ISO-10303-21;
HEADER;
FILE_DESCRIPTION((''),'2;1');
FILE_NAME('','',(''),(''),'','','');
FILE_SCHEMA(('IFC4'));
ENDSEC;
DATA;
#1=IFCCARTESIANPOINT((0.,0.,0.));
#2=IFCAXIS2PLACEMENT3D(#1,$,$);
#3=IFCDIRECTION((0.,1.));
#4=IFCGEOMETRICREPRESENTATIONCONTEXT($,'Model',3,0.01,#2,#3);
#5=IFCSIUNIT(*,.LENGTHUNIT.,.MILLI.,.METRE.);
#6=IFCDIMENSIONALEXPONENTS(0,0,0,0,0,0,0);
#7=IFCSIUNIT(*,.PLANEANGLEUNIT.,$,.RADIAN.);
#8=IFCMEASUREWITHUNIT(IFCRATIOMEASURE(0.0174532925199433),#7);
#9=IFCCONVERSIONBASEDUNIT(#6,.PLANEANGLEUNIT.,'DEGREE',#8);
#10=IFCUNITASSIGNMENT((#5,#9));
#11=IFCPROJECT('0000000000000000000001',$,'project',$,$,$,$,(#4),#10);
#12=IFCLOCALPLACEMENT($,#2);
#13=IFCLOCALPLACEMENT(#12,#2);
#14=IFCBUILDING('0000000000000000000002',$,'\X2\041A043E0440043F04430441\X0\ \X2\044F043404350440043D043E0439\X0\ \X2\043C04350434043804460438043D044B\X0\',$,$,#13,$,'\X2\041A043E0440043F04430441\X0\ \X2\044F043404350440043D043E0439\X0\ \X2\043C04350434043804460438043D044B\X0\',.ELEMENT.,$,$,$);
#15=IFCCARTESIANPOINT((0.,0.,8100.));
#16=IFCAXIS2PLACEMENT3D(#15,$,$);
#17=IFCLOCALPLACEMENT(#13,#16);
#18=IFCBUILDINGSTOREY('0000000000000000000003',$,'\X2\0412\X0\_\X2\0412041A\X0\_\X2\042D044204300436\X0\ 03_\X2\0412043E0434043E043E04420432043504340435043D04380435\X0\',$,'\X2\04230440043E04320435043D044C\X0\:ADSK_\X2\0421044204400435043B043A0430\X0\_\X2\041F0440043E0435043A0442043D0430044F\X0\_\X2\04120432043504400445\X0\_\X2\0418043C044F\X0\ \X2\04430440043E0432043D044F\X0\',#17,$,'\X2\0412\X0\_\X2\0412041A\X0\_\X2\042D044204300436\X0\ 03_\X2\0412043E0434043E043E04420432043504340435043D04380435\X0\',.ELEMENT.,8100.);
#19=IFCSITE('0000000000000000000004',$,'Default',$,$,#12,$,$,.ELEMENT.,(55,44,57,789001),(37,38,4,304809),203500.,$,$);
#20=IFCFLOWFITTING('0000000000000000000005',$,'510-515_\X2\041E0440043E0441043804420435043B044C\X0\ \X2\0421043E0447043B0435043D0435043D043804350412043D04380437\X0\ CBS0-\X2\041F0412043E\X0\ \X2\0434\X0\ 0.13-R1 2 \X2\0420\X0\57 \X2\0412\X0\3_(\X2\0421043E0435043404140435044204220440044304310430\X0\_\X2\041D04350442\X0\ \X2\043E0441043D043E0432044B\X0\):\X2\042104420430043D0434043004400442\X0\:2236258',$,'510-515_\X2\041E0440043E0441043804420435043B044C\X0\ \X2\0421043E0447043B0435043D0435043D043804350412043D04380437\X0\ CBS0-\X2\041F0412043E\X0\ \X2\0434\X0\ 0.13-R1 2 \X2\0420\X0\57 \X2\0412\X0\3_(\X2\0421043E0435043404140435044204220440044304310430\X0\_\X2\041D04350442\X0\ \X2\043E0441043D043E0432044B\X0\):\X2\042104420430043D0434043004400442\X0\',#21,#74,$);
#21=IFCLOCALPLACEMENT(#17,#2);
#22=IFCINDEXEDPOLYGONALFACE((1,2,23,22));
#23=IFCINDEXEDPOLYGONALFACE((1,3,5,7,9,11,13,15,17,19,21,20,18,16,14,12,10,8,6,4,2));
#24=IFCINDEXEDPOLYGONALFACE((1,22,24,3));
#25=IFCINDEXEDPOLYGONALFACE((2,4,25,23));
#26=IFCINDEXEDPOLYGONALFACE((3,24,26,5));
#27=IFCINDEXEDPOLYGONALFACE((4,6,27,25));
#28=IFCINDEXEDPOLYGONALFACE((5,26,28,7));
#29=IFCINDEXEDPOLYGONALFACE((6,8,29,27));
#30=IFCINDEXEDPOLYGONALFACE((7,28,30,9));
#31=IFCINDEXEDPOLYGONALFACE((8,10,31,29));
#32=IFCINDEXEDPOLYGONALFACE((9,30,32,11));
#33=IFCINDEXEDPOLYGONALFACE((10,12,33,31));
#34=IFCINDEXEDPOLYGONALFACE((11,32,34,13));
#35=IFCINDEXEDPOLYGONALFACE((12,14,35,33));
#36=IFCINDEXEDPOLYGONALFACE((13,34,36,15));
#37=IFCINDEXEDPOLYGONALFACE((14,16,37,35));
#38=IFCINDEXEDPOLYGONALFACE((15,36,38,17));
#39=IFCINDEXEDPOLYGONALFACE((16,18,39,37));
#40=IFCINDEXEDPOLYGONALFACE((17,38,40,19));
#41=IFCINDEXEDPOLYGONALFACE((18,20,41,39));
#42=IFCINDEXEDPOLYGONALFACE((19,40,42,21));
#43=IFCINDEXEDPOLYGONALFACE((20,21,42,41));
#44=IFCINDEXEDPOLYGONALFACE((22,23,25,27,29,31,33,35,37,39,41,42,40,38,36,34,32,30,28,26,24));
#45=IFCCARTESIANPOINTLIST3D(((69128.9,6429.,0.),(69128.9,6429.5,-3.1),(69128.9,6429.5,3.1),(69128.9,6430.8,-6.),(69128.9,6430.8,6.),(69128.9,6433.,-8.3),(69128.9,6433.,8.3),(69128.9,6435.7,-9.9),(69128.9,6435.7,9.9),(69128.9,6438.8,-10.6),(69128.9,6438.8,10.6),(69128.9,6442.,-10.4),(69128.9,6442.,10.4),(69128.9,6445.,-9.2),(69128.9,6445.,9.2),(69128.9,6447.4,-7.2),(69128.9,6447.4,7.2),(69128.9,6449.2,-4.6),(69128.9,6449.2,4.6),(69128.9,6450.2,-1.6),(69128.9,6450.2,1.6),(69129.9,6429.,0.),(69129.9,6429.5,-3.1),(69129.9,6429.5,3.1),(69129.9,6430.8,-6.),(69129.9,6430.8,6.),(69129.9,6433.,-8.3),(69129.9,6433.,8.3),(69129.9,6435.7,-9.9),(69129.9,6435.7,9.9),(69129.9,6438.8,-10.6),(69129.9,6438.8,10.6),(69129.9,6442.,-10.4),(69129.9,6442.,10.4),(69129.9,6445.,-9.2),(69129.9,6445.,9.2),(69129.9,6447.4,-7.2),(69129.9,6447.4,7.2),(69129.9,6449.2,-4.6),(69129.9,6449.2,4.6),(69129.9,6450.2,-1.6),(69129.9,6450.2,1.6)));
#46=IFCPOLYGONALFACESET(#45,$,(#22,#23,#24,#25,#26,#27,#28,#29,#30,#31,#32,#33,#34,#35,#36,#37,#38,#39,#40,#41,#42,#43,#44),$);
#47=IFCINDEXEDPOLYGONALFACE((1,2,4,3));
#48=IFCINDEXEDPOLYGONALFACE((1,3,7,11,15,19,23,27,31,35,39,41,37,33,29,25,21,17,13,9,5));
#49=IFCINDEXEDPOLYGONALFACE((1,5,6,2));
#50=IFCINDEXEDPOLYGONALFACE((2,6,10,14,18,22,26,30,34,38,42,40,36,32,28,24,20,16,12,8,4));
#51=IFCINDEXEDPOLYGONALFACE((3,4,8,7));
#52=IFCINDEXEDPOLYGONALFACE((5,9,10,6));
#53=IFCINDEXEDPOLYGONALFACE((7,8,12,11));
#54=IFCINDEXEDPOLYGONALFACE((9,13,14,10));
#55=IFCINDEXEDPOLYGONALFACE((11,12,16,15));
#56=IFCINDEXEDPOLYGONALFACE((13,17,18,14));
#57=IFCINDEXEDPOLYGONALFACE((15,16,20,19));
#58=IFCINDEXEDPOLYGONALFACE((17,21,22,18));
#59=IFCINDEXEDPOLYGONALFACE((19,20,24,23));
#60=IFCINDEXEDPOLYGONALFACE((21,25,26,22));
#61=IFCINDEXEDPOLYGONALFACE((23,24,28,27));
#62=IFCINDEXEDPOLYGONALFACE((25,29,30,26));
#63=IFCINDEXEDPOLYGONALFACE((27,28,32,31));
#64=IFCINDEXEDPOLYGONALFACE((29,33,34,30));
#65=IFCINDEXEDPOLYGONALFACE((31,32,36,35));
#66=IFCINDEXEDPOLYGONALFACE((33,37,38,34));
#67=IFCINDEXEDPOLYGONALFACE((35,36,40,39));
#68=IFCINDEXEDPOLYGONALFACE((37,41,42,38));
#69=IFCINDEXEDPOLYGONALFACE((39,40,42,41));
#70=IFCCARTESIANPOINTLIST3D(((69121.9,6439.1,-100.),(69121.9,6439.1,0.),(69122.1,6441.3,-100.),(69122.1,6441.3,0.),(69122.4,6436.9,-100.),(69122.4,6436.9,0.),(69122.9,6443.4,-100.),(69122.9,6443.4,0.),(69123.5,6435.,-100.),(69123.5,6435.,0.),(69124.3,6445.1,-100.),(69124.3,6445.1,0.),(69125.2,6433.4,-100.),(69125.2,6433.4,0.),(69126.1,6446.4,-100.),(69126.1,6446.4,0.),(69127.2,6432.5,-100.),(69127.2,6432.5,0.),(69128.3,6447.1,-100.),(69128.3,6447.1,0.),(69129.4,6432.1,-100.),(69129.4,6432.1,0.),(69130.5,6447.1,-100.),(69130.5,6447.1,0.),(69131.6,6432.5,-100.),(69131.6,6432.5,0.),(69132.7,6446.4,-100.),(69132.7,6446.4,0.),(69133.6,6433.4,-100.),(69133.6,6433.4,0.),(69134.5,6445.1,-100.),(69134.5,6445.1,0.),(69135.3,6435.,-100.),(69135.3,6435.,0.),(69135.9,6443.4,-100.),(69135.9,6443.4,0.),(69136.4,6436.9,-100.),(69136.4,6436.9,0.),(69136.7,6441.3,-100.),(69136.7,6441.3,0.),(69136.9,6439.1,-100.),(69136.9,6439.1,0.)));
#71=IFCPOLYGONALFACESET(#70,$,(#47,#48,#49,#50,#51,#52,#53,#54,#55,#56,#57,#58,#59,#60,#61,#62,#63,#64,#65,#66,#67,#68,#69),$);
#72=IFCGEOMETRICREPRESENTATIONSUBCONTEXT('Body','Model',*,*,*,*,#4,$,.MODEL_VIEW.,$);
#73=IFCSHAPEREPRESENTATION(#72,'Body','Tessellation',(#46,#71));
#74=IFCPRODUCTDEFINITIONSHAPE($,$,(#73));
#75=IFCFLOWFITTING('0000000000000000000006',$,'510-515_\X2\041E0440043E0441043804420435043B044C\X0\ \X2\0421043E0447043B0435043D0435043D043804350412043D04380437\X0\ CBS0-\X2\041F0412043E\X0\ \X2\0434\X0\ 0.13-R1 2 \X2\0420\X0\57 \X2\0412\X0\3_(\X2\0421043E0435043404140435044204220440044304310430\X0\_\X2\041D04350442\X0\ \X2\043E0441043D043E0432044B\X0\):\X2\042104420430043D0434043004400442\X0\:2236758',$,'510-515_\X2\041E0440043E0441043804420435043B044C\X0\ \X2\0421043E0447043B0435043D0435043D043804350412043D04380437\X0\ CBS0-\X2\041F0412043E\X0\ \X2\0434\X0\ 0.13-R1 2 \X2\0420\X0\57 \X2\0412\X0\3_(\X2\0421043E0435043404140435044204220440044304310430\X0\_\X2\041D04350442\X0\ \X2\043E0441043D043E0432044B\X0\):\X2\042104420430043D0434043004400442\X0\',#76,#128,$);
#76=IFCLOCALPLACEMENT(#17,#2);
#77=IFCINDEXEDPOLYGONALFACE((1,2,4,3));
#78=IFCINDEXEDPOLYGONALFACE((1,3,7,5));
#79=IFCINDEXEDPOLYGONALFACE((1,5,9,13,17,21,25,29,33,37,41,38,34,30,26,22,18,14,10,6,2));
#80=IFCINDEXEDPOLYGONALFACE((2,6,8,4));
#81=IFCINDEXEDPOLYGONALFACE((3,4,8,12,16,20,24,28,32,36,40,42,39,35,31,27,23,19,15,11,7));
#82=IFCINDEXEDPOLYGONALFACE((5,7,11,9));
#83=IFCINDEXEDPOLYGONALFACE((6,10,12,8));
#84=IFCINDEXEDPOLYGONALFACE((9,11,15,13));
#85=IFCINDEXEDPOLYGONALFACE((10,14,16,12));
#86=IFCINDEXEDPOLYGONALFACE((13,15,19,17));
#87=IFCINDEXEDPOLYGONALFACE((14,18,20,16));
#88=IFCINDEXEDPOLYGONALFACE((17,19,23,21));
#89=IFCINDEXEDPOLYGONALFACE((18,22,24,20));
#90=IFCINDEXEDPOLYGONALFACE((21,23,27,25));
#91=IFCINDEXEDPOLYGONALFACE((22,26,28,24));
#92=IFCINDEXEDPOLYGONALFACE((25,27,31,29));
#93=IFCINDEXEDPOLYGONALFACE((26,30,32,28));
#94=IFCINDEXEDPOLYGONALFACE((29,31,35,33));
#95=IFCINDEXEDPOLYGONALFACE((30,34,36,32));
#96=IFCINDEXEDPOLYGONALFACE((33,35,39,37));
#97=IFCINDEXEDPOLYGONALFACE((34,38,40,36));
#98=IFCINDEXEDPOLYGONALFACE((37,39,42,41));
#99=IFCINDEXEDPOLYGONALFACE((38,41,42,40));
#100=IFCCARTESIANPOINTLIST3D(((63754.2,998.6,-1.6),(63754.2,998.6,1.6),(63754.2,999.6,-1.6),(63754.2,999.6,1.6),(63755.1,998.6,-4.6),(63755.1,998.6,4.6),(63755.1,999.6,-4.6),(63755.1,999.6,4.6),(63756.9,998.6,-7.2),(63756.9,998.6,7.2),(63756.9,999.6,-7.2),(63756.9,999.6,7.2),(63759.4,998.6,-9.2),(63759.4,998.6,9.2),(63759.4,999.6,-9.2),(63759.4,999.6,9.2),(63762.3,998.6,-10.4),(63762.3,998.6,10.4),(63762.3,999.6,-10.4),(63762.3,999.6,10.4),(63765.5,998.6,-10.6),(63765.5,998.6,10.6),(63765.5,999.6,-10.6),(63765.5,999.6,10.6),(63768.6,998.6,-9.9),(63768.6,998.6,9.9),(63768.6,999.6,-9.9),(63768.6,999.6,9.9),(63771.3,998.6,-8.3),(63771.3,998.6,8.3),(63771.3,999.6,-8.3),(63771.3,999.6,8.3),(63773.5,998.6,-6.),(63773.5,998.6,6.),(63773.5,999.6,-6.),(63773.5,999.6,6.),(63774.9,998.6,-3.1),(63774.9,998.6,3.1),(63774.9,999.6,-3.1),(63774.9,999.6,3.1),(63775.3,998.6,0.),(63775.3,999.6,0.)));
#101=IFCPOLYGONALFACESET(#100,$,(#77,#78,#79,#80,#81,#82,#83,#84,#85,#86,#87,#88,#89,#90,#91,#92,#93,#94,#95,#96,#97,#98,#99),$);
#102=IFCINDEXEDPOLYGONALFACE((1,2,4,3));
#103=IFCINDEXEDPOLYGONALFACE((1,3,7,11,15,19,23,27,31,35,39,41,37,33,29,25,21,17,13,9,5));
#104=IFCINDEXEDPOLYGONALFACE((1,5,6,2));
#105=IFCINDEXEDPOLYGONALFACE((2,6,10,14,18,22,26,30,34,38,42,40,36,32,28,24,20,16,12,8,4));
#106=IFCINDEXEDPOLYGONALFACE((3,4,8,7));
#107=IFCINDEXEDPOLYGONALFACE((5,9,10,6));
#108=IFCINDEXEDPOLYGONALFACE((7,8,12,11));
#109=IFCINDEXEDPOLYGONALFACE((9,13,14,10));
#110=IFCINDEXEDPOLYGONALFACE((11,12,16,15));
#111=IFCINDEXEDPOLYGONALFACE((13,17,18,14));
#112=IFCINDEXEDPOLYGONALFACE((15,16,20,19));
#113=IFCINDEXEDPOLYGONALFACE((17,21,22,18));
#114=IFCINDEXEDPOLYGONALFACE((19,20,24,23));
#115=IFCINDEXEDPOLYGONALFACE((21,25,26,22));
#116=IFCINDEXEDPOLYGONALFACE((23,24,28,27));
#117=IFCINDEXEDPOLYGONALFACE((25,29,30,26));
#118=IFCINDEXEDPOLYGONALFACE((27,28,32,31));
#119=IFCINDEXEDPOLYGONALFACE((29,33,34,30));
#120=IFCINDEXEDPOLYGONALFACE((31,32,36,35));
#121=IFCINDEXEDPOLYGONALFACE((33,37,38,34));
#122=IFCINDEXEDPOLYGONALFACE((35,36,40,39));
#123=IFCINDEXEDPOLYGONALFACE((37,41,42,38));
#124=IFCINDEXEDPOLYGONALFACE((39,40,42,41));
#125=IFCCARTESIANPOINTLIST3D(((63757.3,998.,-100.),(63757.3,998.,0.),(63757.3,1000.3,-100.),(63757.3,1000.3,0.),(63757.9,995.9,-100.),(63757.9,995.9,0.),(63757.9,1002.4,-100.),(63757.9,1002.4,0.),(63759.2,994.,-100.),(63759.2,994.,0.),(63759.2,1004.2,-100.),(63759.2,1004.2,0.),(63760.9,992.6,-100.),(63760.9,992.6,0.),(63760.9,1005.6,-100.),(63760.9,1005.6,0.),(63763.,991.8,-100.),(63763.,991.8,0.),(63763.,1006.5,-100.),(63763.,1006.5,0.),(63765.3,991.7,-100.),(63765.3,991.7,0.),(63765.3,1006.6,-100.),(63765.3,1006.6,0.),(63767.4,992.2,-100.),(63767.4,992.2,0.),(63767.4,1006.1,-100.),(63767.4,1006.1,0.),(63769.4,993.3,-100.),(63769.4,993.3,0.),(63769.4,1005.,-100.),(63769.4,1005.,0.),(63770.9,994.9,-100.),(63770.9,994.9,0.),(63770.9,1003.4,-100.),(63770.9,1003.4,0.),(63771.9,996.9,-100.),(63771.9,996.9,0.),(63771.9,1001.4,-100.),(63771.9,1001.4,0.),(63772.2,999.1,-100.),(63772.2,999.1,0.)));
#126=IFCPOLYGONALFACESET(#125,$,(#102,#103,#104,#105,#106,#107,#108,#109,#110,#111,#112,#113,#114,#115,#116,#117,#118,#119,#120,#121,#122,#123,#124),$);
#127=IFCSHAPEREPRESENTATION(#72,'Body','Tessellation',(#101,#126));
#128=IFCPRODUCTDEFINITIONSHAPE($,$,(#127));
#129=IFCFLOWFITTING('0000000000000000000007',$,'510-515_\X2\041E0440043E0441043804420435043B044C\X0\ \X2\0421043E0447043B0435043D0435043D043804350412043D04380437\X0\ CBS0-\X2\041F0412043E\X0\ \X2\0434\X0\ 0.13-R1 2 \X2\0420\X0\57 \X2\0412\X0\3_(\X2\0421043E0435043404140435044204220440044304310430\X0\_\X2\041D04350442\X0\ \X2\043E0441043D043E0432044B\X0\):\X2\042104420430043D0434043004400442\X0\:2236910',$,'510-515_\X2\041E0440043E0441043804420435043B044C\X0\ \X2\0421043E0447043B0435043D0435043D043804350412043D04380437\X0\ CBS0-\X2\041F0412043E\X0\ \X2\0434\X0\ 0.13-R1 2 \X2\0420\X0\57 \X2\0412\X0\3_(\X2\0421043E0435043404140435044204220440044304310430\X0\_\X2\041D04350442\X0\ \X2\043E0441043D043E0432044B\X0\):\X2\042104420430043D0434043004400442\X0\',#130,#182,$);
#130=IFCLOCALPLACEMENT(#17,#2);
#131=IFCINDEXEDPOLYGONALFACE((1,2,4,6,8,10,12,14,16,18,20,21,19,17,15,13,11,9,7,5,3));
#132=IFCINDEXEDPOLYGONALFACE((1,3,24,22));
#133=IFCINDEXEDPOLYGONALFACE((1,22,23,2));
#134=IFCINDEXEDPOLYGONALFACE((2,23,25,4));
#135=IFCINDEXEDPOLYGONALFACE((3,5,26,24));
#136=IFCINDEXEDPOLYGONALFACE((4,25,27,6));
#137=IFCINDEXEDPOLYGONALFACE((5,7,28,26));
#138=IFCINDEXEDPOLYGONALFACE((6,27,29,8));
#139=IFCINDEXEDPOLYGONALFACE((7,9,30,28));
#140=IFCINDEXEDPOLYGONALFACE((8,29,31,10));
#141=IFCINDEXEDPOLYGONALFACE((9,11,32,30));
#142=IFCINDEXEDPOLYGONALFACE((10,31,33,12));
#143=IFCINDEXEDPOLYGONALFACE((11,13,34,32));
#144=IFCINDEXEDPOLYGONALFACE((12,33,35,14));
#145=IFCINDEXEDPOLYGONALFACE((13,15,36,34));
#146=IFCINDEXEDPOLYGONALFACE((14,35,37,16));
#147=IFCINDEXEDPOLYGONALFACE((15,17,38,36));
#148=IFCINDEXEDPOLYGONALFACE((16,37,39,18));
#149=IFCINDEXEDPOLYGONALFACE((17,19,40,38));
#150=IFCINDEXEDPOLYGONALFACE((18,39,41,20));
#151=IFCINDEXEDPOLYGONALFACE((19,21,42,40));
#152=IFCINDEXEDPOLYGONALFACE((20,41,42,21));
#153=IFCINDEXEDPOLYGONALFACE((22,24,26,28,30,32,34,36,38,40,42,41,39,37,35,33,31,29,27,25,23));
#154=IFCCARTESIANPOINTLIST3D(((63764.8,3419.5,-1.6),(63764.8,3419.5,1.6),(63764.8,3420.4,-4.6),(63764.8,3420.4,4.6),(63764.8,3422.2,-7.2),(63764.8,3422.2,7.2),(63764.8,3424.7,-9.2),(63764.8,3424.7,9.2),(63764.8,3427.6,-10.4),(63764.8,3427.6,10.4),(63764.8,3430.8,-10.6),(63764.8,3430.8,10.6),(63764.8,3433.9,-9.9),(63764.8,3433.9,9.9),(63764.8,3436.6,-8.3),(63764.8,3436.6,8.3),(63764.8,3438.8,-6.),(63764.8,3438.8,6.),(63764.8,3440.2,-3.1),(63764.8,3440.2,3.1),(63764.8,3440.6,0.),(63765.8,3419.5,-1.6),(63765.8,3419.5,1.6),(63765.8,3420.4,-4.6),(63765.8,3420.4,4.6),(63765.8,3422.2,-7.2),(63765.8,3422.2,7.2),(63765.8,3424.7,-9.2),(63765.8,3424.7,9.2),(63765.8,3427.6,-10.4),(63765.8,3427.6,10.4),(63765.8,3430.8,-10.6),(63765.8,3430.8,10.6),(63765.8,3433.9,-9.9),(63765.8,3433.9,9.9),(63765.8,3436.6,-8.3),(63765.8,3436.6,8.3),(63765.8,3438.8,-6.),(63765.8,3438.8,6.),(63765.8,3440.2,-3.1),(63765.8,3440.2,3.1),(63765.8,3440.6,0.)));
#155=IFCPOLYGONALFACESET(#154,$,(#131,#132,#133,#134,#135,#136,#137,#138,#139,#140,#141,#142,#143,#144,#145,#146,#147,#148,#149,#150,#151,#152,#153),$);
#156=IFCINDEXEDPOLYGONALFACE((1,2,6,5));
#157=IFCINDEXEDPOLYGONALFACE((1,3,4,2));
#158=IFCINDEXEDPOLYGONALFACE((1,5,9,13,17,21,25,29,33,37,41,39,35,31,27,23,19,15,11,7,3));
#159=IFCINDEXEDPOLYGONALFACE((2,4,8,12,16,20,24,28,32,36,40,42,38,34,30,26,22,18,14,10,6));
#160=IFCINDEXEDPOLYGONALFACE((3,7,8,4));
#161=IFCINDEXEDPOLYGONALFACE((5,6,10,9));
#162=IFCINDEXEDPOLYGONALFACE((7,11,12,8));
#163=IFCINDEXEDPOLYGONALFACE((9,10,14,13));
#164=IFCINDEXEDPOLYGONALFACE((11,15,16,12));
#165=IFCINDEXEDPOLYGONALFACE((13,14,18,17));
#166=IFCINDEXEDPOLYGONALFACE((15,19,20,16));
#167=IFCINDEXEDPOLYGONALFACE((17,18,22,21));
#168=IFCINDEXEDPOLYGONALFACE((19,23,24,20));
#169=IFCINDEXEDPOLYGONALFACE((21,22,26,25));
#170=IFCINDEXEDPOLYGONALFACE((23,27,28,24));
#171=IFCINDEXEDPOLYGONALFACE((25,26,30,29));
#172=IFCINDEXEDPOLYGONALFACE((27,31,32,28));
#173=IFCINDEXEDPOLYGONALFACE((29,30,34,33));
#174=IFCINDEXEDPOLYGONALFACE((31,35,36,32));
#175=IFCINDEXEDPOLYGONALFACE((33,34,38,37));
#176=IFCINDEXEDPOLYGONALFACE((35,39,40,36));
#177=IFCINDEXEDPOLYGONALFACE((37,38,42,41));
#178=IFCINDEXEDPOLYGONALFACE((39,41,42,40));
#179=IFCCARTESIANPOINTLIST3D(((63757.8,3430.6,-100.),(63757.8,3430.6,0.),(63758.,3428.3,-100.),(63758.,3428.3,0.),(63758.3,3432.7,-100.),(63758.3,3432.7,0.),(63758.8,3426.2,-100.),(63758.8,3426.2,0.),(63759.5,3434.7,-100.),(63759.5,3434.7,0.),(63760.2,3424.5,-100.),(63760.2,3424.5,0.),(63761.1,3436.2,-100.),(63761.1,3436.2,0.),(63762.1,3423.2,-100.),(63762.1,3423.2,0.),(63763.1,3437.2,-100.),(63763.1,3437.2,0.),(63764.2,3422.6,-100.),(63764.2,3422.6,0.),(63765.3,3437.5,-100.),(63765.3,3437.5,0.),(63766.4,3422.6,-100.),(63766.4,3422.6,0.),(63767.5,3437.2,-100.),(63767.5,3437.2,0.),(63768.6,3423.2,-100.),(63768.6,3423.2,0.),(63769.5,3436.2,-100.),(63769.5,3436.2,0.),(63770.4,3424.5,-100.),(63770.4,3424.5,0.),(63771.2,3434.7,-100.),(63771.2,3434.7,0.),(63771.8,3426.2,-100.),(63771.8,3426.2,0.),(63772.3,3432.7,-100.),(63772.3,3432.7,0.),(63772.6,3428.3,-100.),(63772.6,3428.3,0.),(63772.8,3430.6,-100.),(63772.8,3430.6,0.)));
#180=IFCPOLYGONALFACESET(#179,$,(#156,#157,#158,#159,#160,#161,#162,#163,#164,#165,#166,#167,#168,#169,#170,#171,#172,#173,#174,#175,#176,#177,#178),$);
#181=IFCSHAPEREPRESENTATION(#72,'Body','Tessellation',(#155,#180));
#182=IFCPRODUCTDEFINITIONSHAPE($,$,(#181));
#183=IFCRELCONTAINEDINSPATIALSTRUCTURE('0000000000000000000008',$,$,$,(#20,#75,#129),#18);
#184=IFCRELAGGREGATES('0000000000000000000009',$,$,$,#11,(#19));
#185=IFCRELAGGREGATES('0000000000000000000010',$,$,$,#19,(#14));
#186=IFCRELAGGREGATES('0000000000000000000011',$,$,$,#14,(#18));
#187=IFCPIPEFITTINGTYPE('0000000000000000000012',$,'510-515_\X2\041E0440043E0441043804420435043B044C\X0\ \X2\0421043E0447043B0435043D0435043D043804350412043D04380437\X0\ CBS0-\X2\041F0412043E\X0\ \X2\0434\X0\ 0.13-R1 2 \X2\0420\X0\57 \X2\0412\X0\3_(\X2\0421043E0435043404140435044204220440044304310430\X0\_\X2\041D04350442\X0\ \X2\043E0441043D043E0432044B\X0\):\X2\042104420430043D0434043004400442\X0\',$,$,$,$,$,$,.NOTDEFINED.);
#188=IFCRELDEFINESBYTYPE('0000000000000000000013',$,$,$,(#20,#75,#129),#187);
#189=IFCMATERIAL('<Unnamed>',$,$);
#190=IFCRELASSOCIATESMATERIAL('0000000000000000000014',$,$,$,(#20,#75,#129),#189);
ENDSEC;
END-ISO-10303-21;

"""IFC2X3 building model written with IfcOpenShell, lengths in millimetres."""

from ifc_helpers import new_model, entity, si_unit, converted_unit, direction, frame, origin, origin_2d_with_axis, place, context, subcontext, project, spatial, circle, extrude, source, transform, mapped, material, type_object, type_shapes, element, save


model = new_model("IFC2X3")

# Units and contexts
model_context = context("Model", 3, precision=0.01, world=origin(), true_north=direction((0.0, 1.0)))
body_context = subcontext(model_context, "Body", "Model", "MODEL_VIEW")
ifc_project = project(units=[si_unit("LENGTHUNIT", "METRE", prefix="MILLI"), converted_unit("PLANEANGLEUNIT", "DEGREE", entity("IfcRatioMeasure", 0.0174532925199433), si_unit("PLANEANGLEUNIT", "RADIAN"), dimensions=[0, 0, 0, 0, 0, 0, 0])], contexts=[model_context])

# Site, building, storey
site_placement = place(None, origin())
site = spatial("IfcSite", under=ifc_project, at=site_placement, Name="Default", CompositionType="ELEMENT", RefLatitude=(55, 44, 57, 789001), RefLongitude=(37, 38, 4, 304809), RefElevation=203500.0)
building_placement = place(site_placement, origin())
building = spatial("IfcBuilding", under=site, at=building_placement, Name="Корпус ядерной медицины", LongName="Корпус ядерной медицины", CompositionType="ELEMENT")
storey_placement = place(building_placement, frame((0.0, 0.0, 8100.0)))
storey = spatial("IfcBuildingStorey", under=building, at=storey_placement, Name="В_ВК_Этаж 03_Водоотведение", ObjectType="Уровень:ADSK_Стрелка_Проектная_Вверх_Имя уровня", LongName="В_ВК_Этаж 03_Водоотведение", CompositionType="ELEMENT", Elevation=8100.0)

# Flow fittings
ifc_material_1 = material(Name="<Unnamed>")
pipe_fitting_type = type_object("IfcPipeFittingType", Name="510-515_Ороситель СочленениеВниз CBS0-ПВо д 0.13-R1 2 Р57 В3_(СоедДетТруба_Нет основы):Стандарт", PredefinedType="NOTDEFINED")
shared_shape_1 = source(origin(), body_context, "Body", "SweptSolid", [
    extrude(circle(Radius=10.7, at=origin_2d_with_axis()), frame((-0.5, 0.0, 0.0), z_axis=(1.0, 0.0, 0.0), x_axis=(0.0, 1.0, 0.0)), (0.0, 0.0, 1.0), 1.0),
    extrude(circle(Radius=7.5, at=origin_2d_with_axis()), frame((0.0, 0.0, -100.0), z_axis=(0.0, 0.0, 1.0), x_axis=(0.0, 1.0, 0.0)), (0.0, 0.0, 1.0), 100.0),
])
type_shapes(pipe_fitting_type, [shared_shape_1])
for number, where, z_axis, x_axis, name in (
    (1, (69129.4, 6439.6, 0.0), (0.0, 0.0, 1.0), (-1.0, 0.0, 0.0), "510-515_Ороситель СочленениеВниз CBS0-ПВо д 0.13-R1 2 Р57 В3_(СоедДетТруба_Нет основы):Стандарт:2236258"),
    (2, (63764.7, 999.1, 0.0), (0.0, 0.0, 1.0), (0.0, -1.0, 0.0), "510-515_Ороситель СочленениеВниз CBS0-ПВо д 0.13-R1 2 Р57 В3_(СоедДетТруба_Нет основы):Стандарт:2236758"),
):
    element("IfcFlowFitting", number, at=place(storey_placement, frame(where, z_axis=z_axis, x_axis=x_axis)), inside=storey, type_object=pipe_fitting_type, material=ifc_material_1, Name=name, ObjectType="510-515_Ороситель СочленениеВниз CBS0-ПВо д 0.13-R1 2 Р57 В3_(СоедДетТруба_Нет основы):Стандарт", context=body_context, shape_type="MappedRepresentation", body=[
        mapped(shared_shape_1, transform((0.0, 0.0, 0.0), scale=1.0)),
    ])
for number, where, name in (
    (3, (63765.3, 3430.0, 0.0), "510-515_Ороситель СочленениеВниз CBS0-ПВо д 0.13-R1 2 Р57 В3_(СоедДетТруба_Нет основы):Стандарт:2236910"),
):
    element("IfcFlowFitting", number, at=place(storey_placement, frame(where)), inside=storey, type_object=pipe_fitting_type, material=ifc_material_1, Name=name, ObjectType="510-515_Ороситель СочленениеВниз CBS0-ПВо д 0.13-R1 2 Р57 В3_(СоедДетТруба_Нет основы):Стандарт", context=body_context, shape_type="MappedRepresentation", body=[
        mapped(shared_shape_1, transform((0.0, 0.0, 0.0), scale=1.0)),
    ])

save(model, "model.ifc")
